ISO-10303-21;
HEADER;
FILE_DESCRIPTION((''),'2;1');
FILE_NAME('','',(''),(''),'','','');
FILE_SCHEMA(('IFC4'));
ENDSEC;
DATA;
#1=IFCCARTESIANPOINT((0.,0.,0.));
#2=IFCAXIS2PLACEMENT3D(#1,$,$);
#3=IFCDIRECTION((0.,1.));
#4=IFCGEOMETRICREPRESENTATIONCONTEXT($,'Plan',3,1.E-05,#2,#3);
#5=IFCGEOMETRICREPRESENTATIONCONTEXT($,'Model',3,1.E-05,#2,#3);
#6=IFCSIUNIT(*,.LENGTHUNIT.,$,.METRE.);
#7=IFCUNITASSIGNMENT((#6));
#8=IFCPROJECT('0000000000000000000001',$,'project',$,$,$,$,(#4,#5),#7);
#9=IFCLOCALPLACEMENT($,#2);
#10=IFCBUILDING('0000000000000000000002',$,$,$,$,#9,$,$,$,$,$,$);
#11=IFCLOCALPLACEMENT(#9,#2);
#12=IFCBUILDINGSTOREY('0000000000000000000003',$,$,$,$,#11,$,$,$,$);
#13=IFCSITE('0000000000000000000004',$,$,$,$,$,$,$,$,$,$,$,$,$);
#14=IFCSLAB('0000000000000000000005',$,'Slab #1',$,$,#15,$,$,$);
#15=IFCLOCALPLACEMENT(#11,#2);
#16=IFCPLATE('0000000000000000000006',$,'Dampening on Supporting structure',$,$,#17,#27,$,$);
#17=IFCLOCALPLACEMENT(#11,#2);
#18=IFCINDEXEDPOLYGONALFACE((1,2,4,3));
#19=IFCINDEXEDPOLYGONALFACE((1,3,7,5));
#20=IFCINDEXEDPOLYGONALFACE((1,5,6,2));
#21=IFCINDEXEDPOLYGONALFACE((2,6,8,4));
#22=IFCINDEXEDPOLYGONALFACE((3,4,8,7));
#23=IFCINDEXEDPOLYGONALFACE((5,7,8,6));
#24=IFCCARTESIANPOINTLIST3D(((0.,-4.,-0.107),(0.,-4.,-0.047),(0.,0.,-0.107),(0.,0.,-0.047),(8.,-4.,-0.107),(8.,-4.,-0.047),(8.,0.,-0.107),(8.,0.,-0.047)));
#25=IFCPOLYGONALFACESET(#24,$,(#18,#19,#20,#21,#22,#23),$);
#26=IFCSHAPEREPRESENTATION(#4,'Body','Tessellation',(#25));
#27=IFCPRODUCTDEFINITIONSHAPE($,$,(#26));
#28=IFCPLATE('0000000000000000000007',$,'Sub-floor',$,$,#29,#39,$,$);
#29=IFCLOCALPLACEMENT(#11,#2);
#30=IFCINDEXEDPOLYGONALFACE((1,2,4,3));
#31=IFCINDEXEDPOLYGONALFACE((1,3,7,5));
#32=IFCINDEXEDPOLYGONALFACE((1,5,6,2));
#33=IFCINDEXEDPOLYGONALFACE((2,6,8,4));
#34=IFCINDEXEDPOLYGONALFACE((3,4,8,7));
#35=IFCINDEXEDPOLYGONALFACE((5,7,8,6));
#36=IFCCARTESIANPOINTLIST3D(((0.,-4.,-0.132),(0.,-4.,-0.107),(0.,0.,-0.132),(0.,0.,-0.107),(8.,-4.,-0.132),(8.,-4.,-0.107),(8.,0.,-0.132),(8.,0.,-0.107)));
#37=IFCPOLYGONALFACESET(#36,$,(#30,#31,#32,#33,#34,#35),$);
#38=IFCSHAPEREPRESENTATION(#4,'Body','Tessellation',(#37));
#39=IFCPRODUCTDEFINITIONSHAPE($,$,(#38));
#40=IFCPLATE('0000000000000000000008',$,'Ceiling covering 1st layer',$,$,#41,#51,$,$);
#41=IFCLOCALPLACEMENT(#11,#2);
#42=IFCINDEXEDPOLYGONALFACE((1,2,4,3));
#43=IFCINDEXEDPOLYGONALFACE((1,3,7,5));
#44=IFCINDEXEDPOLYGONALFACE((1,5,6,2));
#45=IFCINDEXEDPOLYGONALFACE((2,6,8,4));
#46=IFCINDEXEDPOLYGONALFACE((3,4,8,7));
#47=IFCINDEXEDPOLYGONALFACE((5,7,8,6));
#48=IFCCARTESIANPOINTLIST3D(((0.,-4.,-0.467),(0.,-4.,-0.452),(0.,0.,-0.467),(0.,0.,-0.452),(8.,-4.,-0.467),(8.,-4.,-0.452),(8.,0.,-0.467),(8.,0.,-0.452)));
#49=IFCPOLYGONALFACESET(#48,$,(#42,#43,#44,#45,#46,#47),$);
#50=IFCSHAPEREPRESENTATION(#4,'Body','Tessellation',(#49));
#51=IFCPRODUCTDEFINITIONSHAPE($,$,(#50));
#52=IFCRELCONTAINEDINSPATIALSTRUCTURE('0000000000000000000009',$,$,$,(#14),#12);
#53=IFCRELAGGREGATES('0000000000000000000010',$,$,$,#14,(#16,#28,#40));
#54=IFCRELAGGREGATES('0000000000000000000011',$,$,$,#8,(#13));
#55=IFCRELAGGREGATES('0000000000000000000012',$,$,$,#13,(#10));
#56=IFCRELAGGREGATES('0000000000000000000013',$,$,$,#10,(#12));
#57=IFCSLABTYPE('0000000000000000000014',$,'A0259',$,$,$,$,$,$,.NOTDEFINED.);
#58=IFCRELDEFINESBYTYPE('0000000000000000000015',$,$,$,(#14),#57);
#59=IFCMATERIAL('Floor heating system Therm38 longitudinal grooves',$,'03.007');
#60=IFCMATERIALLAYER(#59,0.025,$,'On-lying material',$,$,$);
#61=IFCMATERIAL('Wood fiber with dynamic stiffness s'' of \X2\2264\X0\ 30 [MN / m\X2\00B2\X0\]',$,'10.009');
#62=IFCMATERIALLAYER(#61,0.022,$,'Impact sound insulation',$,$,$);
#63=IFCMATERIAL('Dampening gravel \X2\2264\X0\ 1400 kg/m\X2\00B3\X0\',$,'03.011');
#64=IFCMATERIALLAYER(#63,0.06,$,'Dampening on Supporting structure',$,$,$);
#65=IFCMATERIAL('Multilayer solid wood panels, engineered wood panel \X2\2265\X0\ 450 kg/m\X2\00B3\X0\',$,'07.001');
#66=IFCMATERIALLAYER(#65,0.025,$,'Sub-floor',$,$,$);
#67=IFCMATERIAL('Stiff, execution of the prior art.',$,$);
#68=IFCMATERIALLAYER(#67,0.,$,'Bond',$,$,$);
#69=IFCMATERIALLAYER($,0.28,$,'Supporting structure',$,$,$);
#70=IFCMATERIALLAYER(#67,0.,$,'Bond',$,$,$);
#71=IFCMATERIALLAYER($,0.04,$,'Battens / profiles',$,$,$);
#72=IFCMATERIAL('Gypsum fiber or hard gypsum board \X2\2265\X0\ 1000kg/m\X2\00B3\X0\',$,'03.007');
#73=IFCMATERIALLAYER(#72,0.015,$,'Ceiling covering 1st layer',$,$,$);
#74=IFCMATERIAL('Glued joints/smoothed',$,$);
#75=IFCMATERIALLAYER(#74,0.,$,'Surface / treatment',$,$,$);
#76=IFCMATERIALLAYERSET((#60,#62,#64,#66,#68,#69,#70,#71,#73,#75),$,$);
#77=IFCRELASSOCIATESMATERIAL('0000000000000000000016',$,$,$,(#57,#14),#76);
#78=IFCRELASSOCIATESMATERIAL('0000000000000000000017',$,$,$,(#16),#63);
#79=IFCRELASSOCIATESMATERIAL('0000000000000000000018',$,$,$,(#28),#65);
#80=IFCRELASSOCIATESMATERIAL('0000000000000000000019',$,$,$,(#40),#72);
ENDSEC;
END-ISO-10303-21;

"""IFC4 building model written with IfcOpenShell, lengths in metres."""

from ifc_helpers import new_model, si_unit, direction, frame, frame_2d, origin, place, context, project, spatial, rectangle, extrude, material, layer, layer_set, type_object, element, aggregate, save


model = new_model("IFC4")

# Units and contexts
plan_context = context("Plan", 3, precision=1e-05, world=origin(), true_north=direction((0.0, 1.0)))
model_context = context("Model", 3, precision=1e-05, world=origin(), true_north=direction((0.0, 1.0)))
ifc_project = project(units=[si_unit("LENGTHUNIT", "METRE")], contexts=[plan_context, model_context])

# Site, building, storey
site = spatial("IfcSite", under=ifc_project)
building_placement = place(None, origin())
building = spatial("IfcBuilding", under=site, at=building_placement)
storey_placement = place(building_placement, origin())
storey = spatial("IfcBuildingStorey", under=building, at=storey_placement)

# Slab, plates
ifc_material_1 = material(Name="Floor heating system Therm38 longitudinal grooves", Category="03.007")
ifc_layer_1 = layer(ifc_material_1, 0.025, Name="On-lying material")
ifc_material_2 = material(Name="Wood fiber with dynamic stiffness s' of ≤ 30 [MN / m²]", Category="10.009")
ifc_layer_2 = layer(ifc_material_2, 0.022, Name="Impact sound insulation")
ifc_material_3 = material(Name="Dampening gravel ≤ 1400 kg/m³", Category="03.011")
ifc_layer_3 = layer(ifc_material_3, 0.06, Name="Dampening on Supporting structure")
ifc_material_4 = material(Name="Multilayer solid wood panels, engineered wood panel ≥ 450 kg/m³", Category="07.001")
ifc_layer_4 = layer(ifc_material_4, 0.025, Name="Sub-floor")
ifc_material_5 = material(Name="Stiff, execution of the prior art.")
ifc_layer_5 = layer(ifc_material_5, 0.0, Name="Bond")
ifc_layer_6 = layer(None, 0.28, Name="Supporting structure")
ifc_layer_7 = layer(ifc_material_5, 0.0, Name="Bond")
ifc_layer_8 = layer(None, 0.04, Name="Battens / profiles")
ifc_material_6 = material(Name="Gypsum fiber or hard gypsum board ≥ 1000kg/m³", Category="03.007")
ifc_layer_9 = layer(ifc_material_6, 0.015, Name="Ceiling covering 1st layer")
ifc_material_7 = material(Name="Glued joints/smoothed")
ifc_layer_10 = layer(ifc_material_7, 0.0, Name="Surface / treatment")
ifc_layer_set = layer_set([ifc_layer_1, ifc_layer_2, ifc_layer_3, ifc_layer_4, ifc_layer_5, ifc_layer_6, ifc_layer_7, ifc_layer_8, ifc_layer_9, ifc_layer_10])
slab_type = type_object("IfcSlabType", Name="A0259", PredefinedType="NOTDEFINED", material=ifc_layer_set)
slab_placement = place(None, frame((0.0, 0.0, 0.0), z_axis=(0.0, 0.0, -1.0), x_axis=(1.0, 0.0, 0.0)))
slab = element("IfcSlab", 1, at=slab_placement, inside=storey, type_object=slab_type, material=ifc_layer_set, Name="Slab #1")
plate_1_placement = place(slab_placement, origin())
plate_1 = element("IfcPlate", 2, at=plate_1_placement, material=ifc_material_3, Name="Dampening on Supporting structure", context=plan_context, shape_type="SweptSolid", body=[
    extrude(rectangle(XDim=8.0, YDim=4.0, at=frame_2d((4.0, 2.0), x_axis=(1.0, 0.0))), frame((0.0, 0.0, 0.047), z_axis=(0.0, 0.0, 1.0), x_axis=(1.0, 0.0, 0.0)), (0.0, 0.0, 1.0), 0.06),
])
plate_2_placement = place(slab_placement, origin())
plate_2 = element("IfcPlate", 3, at=plate_2_placement, material=ifc_material_4, Name="Sub-floor", context=plan_context, shape_type="SweptSolid", body=[
    extrude(rectangle(XDim=8.0, YDim=4.0, at=frame_2d((4.0, 2.0), x_axis=(1.0, 0.0))), frame((0.0, 0.0, 0.107), z_axis=(0.0, 0.0, 1.0), x_axis=(1.0, 0.0, 0.0)), (0.0, 0.0, 1.0), 0.025),
])
plate_3_placement = place(slab_placement, origin())
plate_3 = element("IfcPlate", 4, at=plate_3_placement, material=ifc_material_6, Name="Ceiling covering 1st layer", context=plan_context, shape_type="SweptSolid", body=[
    extrude(rectangle(XDim=8.0, YDim=4.0, at=frame_2d((4.0, 2.0), x_axis=(1.0, 0.0))), frame((0.0, 0.0, 0.452), z_axis=(0.0, 0.0, 1.0), x_axis=(1.0, 0.0, 0.0)), (0.0, 0.0, 1.0), 0.015),
])
aggregate(slab, [plate_1, plate_2, plate_3])

save(model, "model.ifc")
